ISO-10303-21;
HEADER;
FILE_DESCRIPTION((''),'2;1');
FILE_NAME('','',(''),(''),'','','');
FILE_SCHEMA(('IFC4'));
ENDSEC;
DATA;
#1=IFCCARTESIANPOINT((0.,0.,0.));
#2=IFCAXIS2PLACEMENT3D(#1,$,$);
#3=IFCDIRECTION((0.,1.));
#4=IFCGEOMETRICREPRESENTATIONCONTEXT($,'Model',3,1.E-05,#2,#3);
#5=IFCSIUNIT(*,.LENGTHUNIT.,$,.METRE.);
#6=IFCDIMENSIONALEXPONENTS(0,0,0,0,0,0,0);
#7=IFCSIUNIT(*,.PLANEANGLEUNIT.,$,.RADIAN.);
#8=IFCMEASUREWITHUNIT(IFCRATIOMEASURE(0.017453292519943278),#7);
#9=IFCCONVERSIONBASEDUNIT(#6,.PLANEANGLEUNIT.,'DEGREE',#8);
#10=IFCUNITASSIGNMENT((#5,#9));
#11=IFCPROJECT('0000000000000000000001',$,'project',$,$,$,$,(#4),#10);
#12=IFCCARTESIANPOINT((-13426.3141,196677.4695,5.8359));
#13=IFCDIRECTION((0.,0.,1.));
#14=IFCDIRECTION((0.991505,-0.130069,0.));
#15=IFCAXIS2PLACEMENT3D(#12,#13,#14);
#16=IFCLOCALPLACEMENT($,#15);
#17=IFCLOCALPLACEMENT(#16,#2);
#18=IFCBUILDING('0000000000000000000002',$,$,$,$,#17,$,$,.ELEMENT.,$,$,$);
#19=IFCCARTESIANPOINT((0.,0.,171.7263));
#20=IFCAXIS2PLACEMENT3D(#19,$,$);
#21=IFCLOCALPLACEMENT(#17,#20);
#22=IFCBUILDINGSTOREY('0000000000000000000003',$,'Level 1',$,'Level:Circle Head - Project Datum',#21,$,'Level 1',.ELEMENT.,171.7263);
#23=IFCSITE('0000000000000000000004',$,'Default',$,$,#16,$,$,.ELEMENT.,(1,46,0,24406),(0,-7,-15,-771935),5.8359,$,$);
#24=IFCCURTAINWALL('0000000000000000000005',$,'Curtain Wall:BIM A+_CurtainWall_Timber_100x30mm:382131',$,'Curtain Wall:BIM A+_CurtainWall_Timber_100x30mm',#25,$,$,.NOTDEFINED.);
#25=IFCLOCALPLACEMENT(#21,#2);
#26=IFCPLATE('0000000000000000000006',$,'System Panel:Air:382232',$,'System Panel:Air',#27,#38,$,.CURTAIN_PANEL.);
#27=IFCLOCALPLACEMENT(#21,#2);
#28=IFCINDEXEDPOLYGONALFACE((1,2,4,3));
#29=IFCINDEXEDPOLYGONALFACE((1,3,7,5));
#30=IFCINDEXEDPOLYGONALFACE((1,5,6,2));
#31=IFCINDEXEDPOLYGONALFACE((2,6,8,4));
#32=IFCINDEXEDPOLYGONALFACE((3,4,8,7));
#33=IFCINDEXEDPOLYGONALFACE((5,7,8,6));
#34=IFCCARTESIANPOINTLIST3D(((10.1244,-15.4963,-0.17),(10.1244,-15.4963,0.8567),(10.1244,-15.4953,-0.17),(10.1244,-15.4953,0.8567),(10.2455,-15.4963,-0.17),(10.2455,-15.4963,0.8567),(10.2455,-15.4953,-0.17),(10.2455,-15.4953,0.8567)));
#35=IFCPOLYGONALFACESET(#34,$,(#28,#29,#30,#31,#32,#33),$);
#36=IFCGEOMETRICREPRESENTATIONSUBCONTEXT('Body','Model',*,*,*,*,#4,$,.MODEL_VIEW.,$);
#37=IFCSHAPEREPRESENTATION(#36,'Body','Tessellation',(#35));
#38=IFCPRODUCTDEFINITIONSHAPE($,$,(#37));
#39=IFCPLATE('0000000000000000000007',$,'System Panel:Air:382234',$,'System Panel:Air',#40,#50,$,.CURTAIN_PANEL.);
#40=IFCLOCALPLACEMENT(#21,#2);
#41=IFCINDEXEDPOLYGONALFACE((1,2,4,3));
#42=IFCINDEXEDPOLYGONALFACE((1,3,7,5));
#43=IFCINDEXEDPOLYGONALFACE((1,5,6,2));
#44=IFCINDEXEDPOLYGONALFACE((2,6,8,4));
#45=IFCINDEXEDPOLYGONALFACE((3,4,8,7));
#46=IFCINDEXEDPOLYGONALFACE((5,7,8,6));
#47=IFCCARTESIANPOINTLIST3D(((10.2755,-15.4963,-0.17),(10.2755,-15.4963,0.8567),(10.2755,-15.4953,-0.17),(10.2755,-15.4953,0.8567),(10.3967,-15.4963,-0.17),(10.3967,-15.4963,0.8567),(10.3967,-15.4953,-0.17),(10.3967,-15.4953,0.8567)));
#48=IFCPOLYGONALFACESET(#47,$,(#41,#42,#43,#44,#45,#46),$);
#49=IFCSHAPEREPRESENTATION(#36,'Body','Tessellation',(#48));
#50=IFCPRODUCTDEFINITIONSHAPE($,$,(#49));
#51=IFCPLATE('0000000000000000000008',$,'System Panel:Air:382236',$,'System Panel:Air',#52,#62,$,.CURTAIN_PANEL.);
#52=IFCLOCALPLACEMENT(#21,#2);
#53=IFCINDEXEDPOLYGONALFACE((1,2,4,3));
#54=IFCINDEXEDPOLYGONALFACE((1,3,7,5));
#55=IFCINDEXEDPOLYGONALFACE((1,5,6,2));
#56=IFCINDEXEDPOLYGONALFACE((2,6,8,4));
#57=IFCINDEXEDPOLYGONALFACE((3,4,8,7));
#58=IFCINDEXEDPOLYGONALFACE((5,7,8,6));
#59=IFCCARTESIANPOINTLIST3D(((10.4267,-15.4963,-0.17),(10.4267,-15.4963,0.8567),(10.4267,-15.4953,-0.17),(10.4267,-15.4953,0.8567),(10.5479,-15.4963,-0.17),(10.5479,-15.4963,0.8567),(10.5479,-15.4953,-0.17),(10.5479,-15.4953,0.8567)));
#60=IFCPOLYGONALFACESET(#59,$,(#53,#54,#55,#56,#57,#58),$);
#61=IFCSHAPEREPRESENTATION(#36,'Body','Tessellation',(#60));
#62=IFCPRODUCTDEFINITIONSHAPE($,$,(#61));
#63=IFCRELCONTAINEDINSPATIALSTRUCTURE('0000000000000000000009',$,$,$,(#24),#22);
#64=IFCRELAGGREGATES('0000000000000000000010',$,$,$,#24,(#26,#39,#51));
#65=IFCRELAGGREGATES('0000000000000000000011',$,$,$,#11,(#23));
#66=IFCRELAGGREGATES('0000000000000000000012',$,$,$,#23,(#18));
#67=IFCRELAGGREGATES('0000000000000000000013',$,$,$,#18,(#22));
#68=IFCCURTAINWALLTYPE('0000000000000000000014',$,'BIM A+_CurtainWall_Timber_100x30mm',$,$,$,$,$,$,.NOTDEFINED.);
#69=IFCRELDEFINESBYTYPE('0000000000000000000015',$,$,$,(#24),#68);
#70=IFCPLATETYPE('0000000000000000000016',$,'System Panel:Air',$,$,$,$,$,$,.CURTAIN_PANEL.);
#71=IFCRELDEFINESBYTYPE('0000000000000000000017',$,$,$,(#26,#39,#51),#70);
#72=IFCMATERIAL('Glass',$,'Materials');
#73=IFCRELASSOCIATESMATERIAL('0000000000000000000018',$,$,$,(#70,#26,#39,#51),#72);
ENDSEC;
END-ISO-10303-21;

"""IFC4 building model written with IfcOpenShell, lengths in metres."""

from ifc_helpers import new_model, entity, si_unit, converted_unit, direction, frame, origin, place, context, subcontext, project, spatial, indexed_curve, outline, extrude, source, transform, mapped, material, type_object, type_shapes, element, aggregate, save


model = new_model("IFC4")

# Units and contexts
model_context = context("Model", 3, precision=1e-05, world=origin(), true_north=direction((0.0, 1.0)))
body_context = subcontext(model_context, "Body", "Model", "MODEL_VIEW")
ifc_project = project(units=[si_unit("LENGTHUNIT", "METRE"), converted_unit("PLANEANGLEUNIT", "DEGREE", entity("IfcRatioMeasure", 0.017453292519943278), si_unit("PLANEANGLEUNIT", "RADIAN"), dimensions=[0, 0, 0, 0, 0, 0, 0])], contexts=[model_context])

# Site, building, storey
site_placement = place(None, frame((-13426.3141, 196677.4695, 5.8359), z_axis=(0.0, 0.0, 1.0), x_axis=(0.991505, -0.130069, 0.0)))
site = spatial("IfcSite", under=ifc_project, at=site_placement, Name="Default", CompositionType="ELEMENT", RefLatitude=(1, 46, 0, 24406), RefLongitude=(0, -7, -15, -771935), RefElevation=5.8359)
building_placement = place(site_placement, origin())
building = spatial("IfcBuilding", under=site, at=building_placement, CompositionType="ELEMENT")
storey_placement = place(building_placement, frame((0.0, 0.0, 171.7263)))
storey = spatial("IfcBuildingStorey", under=building, at=storey_placement, Name="Level 1", ObjectType="Level:Circle Head - Project Datum", LongName="Level 1", CompositionType="ELEMENT", Elevation=171.7263)

# Curtain wall
curtain_wall_type_1 = type_object("IfcCurtainWallType", Name="BIM A+_CurtainWall_Timber_100x30mm", PredefinedType="NOTDEFINED")
curtain_wall_1_placement = place(storey_placement, frame((0.0, 0.0, -171.7263)))
curtain_wall_1 = element("IfcCurtainWall", 1, at=curtain_wall_1_placement, inside=storey, type_object=curtain_wall_type_1, Name="Curtain Wall:BIM A+_CurtainWall_Timber_100x30mm:382131", ObjectType="Curtain Wall:BIM A+_CurtainWall_Timber_100x30mm", PredefinedType="NOTDEFINED")

# Plates
ifc_material_1 = material(Name="Glass", Category="Materials")
plate_type_1 = type_object("IfcPlateType", Name="System Panel:Air", PredefinedType="CURTAIN_PANEL", material=ifc_material_1)
shared_shape_1 = source(origin(), body_context, "Body", "SweptSolid", [
    extrude(outline(indexed_curve([(-0.0005, -0.0606), (0.0005, -0.0606), (0.0005, 0.0606), (-0.0005, 0.0606), (-0.0005, -0.0606)], self_intersect=False)), frame((0.0, 0.0, 0.0), z_axis=(0.0, 0.0, 1.0), x_axis=(0.0, 1.0, 0.0)), (0.0, 0.0, 1.0), 1.0267),
])
type_shapes(plate_type_1, [shared_shape_1])
plate_1_placement = place(curtain_wall_1_placement, frame((10.185, -15.4958, 171.5563)))
plate_1 = element("IfcPlate", 2, at=plate_1_placement, type_object=plate_type_1, material=ifc_material_1, Name="System Panel:Air:382232", ObjectType="System Panel:Air", PredefinedType="CURTAIN_PANEL", context=body_context, shape_type="MappedRepresentation", body=[
    mapped(shared_shape_1, transform((0.0, 0.0, 0.0), scale=1.0)),
])
plate_2_placement = place(curtain_wall_1_placement, frame((10.3361, -15.4958, 171.5563)))
plate_2 = element("IfcPlate", 3, at=plate_2_placement, type_object=plate_type_1, material=ifc_material_1, Name="System Panel:Air:382234", ObjectType="System Panel:Air", PredefinedType="CURTAIN_PANEL", context=body_context, shape_type="MappedRepresentation", body=[
    mapped(shared_shape_1, transform((0.0, 0.0, 0.0), scale=1.0)),
])
plate_3_placement = place(curtain_wall_1_placement, frame((10.4873, -15.4958, 171.5563)))
plate_3 = element("IfcPlate", 4, at=plate_3_placement, type_object=plate_type_1, material=ifc_material_1, Name="System Panel:Air:382236", ObjectType="System Panel:Air", PredefinedType="CURTAIN_PANEL", context=body_context, shape_type="MappedRepresentation", body=[
    mapped(shared_shape_1, transform((0.0, 0.0, 0.0), scale=1.0)),
])
aggregate(curtain_wall_1, [plate_1, plate_2, plate_3])

save(model, "model.ifc")
